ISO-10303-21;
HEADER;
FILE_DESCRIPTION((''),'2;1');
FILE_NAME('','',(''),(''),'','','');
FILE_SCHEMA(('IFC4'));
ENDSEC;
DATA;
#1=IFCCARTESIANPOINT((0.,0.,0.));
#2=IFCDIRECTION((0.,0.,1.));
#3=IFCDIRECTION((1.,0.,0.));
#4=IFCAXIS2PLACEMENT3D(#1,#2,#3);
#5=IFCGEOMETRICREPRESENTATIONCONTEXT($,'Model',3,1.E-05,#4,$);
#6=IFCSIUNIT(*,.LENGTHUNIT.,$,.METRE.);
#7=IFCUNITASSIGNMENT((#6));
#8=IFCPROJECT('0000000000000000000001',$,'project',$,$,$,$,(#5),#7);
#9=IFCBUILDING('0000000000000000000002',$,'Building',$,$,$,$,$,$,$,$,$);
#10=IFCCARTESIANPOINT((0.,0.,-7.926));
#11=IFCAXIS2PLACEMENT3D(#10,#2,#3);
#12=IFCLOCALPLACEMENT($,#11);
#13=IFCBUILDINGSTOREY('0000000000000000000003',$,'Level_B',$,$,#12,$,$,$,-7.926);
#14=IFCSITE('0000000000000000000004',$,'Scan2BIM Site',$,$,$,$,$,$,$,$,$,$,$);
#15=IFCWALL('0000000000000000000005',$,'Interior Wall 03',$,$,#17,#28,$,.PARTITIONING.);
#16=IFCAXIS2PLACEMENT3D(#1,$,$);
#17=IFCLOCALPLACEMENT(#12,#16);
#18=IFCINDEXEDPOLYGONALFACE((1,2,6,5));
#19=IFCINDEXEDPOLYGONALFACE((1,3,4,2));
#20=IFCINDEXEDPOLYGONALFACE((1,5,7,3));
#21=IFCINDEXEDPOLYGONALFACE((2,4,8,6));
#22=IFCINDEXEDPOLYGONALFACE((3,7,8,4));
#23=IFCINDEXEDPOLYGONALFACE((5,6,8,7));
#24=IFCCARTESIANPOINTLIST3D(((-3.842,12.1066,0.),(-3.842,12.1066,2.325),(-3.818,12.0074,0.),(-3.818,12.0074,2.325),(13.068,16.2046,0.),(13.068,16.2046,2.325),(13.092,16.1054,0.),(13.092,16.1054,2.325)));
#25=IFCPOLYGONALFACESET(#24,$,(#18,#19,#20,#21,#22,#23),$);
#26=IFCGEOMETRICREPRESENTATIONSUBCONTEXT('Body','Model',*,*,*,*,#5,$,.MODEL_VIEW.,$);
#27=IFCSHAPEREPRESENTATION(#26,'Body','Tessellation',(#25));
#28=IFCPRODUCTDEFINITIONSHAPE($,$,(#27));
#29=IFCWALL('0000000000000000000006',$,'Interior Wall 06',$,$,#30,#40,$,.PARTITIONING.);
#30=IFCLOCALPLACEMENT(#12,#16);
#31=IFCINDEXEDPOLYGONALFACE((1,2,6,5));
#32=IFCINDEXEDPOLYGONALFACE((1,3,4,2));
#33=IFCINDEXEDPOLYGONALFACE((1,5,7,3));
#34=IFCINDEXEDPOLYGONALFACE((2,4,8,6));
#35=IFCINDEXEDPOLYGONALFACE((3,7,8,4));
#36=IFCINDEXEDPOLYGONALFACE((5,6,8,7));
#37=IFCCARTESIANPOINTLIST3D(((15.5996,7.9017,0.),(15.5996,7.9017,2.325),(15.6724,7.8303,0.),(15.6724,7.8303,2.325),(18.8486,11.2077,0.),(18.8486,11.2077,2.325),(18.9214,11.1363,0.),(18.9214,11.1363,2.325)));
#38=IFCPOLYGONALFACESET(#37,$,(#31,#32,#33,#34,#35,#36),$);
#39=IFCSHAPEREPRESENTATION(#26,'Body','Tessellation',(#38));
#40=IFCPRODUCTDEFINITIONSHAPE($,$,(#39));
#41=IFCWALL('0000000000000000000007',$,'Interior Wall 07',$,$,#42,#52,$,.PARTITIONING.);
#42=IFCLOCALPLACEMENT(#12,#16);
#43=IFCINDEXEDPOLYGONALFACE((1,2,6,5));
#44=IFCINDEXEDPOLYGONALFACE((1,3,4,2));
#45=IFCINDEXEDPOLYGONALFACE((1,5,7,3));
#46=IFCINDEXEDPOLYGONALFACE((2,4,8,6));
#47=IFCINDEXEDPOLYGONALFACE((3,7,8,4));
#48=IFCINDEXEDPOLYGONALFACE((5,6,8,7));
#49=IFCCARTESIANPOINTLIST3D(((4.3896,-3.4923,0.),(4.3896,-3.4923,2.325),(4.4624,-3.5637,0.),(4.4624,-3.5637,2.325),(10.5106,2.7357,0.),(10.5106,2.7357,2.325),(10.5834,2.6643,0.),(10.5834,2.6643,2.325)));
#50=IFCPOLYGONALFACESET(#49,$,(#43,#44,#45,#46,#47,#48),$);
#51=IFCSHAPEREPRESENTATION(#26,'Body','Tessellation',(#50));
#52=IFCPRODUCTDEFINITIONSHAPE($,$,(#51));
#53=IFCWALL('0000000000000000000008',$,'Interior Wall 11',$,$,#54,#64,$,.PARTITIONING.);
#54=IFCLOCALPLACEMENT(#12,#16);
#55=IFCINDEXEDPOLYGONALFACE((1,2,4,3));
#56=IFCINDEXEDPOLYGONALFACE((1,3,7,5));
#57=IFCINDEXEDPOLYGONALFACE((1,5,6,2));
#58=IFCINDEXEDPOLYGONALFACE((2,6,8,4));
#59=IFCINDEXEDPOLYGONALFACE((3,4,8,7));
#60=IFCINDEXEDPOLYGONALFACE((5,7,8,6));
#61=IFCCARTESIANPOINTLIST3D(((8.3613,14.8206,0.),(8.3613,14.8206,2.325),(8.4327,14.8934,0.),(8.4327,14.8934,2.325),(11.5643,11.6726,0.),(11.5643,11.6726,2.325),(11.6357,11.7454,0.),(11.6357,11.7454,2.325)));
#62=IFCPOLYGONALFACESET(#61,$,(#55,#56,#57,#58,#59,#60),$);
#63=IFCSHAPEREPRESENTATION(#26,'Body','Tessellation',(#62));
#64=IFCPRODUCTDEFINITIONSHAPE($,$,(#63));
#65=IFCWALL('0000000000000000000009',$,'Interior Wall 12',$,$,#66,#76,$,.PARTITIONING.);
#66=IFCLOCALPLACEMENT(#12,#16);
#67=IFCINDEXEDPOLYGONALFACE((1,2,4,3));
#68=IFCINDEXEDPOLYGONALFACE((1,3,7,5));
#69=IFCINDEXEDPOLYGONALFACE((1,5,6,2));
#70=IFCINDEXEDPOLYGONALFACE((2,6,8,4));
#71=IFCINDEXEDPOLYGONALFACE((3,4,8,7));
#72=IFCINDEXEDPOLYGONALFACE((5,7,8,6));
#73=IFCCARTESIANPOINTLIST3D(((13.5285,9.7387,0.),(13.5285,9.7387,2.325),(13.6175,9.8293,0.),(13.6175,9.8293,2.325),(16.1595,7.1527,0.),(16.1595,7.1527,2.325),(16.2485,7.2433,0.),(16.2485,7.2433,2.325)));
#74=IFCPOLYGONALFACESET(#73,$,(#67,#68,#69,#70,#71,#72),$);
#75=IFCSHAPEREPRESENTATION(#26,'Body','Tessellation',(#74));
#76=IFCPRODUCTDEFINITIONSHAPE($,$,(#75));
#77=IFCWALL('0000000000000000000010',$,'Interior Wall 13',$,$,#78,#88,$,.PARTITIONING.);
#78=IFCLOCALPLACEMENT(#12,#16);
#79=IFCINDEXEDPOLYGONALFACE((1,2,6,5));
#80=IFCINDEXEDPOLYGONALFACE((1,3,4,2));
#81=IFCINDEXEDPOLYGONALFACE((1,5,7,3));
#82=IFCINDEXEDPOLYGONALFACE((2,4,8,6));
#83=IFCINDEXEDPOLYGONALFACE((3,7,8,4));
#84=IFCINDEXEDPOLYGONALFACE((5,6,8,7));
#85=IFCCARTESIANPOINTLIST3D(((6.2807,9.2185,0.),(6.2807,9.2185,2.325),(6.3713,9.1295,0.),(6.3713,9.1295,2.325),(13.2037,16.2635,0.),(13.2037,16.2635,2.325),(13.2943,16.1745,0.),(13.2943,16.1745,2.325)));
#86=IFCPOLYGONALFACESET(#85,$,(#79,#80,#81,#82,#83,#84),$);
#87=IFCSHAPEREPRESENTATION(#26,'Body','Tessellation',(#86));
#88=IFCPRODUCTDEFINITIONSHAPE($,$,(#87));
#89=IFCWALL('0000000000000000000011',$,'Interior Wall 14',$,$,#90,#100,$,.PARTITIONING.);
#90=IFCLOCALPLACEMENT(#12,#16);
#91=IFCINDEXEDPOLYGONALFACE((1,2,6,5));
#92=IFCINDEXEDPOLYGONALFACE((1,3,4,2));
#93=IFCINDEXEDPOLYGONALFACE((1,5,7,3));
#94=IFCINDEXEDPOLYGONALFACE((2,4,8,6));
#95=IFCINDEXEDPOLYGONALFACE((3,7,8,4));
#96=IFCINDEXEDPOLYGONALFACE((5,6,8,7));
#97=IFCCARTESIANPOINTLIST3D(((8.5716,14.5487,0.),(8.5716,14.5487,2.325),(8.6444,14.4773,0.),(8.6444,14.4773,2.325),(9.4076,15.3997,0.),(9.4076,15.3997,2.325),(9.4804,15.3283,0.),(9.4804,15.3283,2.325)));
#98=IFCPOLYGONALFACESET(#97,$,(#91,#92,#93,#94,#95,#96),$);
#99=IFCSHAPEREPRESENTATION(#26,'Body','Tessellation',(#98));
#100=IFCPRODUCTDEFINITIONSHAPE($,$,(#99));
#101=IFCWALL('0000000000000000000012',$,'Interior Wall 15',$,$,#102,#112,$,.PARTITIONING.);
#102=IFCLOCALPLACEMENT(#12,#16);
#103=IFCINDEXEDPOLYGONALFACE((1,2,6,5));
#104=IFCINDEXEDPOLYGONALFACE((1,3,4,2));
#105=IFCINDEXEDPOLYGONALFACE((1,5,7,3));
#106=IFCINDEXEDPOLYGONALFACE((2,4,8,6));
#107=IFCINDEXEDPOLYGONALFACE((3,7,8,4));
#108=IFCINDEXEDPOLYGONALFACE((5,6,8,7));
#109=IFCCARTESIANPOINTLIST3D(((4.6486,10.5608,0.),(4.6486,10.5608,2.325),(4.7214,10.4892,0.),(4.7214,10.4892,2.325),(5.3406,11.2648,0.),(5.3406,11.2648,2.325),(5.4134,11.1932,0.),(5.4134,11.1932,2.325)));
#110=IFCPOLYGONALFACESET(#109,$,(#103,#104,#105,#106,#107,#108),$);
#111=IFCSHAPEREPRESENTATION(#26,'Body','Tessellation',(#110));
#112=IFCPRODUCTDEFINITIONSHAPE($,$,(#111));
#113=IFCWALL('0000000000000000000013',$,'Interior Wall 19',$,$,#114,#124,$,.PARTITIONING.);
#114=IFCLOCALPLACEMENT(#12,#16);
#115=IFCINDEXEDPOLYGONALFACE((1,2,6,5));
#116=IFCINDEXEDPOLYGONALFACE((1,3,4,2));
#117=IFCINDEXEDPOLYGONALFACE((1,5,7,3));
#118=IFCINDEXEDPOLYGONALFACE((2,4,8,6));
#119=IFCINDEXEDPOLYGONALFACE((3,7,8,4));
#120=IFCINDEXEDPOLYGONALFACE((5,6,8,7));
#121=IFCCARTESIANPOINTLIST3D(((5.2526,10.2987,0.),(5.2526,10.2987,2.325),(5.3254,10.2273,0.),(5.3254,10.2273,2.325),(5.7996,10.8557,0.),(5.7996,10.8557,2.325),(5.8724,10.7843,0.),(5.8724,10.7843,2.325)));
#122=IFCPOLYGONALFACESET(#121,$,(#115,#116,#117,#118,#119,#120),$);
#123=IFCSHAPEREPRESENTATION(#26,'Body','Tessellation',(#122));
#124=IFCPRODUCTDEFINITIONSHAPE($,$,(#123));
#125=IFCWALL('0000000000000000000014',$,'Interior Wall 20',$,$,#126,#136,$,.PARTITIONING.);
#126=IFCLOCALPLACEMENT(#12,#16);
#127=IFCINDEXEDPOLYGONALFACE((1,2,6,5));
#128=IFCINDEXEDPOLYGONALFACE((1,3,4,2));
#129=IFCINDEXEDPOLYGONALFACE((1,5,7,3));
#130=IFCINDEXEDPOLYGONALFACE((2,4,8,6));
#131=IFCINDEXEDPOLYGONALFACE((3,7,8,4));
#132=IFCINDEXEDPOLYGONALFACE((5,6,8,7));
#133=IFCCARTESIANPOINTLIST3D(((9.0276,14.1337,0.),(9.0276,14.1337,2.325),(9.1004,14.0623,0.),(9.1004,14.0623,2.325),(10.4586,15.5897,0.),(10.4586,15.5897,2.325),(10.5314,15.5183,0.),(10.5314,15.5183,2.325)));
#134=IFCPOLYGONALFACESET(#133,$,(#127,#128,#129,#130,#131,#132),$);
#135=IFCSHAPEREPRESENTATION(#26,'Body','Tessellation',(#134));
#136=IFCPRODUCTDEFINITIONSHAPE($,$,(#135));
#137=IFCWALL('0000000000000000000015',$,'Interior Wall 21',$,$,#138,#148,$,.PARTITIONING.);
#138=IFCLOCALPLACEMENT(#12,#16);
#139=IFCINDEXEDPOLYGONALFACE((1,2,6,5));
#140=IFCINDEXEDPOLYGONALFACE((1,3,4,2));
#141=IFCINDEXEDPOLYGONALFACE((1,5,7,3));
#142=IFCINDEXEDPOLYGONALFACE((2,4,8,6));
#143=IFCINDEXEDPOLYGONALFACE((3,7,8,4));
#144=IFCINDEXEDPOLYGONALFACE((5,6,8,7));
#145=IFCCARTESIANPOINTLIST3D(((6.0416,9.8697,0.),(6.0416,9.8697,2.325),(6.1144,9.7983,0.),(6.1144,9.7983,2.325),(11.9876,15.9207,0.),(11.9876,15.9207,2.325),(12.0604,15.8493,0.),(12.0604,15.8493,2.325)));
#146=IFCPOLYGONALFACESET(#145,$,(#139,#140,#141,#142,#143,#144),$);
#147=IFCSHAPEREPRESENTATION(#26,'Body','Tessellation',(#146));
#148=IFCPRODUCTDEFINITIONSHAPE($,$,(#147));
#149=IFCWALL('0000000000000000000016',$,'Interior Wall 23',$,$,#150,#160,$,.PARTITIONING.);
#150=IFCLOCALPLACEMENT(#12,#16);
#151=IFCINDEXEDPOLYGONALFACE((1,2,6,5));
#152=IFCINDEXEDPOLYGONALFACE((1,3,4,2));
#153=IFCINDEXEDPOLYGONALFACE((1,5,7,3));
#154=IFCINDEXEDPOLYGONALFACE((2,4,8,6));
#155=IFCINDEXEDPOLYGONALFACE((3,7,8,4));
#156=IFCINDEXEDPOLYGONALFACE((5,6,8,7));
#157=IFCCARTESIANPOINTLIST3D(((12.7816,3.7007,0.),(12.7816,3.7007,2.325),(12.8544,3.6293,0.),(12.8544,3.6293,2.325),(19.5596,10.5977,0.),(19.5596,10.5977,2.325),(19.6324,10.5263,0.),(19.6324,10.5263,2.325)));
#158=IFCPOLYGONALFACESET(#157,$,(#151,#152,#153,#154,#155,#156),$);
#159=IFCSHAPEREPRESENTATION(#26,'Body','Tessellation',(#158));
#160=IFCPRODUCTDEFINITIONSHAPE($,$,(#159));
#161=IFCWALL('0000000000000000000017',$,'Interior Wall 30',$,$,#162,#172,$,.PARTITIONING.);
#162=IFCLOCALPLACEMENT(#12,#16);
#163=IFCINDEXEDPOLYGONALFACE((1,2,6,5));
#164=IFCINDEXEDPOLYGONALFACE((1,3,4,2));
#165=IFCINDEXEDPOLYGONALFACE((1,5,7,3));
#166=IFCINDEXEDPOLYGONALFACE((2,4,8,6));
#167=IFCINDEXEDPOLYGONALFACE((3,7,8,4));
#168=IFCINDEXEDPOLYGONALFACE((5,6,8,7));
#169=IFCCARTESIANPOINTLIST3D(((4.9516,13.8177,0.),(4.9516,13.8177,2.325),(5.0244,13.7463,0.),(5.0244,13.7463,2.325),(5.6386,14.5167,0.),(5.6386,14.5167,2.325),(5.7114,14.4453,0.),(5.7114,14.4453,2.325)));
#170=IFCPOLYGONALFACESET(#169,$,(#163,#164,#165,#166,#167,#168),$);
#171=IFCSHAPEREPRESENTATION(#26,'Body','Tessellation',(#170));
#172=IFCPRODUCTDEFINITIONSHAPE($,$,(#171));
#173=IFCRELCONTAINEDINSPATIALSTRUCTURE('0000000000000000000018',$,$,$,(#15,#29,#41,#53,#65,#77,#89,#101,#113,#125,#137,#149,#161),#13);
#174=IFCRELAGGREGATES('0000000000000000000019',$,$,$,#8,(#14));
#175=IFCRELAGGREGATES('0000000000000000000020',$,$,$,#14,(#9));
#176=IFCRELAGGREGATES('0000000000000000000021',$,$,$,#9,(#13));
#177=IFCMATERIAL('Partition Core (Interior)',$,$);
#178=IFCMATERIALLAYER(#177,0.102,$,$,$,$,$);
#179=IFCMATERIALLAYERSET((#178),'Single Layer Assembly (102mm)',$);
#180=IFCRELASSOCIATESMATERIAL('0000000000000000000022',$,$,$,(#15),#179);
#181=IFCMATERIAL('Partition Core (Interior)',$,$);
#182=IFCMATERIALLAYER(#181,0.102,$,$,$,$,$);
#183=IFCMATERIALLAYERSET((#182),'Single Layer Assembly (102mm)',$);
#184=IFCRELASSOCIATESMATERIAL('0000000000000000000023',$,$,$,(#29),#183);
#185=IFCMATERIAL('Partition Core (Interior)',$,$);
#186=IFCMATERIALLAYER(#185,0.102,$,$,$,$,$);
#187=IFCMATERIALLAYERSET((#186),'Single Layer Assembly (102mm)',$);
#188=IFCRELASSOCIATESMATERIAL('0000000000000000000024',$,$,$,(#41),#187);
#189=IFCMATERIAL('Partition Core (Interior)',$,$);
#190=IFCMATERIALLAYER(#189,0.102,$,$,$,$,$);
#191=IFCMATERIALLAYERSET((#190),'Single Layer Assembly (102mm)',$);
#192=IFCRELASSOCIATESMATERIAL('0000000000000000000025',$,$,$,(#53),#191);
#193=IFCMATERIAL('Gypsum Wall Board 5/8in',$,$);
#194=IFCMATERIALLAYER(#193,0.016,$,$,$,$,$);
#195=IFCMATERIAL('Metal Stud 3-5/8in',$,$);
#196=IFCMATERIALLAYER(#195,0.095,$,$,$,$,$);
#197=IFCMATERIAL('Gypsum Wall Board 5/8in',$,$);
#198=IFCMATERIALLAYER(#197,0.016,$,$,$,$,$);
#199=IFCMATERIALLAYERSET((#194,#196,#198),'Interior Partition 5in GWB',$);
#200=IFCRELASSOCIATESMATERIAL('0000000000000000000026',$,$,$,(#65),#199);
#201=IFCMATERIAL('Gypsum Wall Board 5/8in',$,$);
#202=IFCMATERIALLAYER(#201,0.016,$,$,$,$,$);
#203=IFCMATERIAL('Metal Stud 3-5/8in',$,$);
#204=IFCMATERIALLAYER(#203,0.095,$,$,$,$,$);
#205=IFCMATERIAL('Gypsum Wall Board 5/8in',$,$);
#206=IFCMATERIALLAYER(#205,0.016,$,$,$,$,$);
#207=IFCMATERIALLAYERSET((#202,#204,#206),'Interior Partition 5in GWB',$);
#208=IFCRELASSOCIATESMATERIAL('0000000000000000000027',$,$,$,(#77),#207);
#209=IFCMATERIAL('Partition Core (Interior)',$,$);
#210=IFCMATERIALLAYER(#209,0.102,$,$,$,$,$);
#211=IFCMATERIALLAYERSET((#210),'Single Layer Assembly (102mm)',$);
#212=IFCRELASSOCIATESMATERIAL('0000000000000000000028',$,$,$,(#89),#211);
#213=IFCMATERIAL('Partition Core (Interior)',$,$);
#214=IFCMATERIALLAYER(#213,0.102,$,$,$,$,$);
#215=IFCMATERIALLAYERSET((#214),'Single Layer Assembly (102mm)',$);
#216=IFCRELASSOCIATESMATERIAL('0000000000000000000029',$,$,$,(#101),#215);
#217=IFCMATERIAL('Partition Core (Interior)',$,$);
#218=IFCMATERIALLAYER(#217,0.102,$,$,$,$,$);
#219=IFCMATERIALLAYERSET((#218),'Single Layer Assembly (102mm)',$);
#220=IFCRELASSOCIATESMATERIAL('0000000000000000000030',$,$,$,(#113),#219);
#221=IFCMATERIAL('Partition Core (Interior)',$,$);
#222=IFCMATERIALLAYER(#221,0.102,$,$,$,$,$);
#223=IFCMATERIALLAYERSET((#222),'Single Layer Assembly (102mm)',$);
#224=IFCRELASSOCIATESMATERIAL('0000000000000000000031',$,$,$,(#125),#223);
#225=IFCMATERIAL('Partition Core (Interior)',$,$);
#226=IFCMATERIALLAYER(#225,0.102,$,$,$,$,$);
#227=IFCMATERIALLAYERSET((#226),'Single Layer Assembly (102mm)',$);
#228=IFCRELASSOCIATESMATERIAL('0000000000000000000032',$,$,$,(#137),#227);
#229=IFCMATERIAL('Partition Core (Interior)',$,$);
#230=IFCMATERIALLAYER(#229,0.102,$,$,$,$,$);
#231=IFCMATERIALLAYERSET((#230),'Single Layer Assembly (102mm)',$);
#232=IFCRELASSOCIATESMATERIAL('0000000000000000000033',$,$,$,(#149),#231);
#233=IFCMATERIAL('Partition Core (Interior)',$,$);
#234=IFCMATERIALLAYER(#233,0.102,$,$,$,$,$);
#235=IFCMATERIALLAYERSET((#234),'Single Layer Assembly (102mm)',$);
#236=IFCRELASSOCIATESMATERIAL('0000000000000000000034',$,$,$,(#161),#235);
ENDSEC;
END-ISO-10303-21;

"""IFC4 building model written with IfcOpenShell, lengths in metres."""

from ifc_helpers import new_model, si_unit, frame, origin, origin_with_axes, place, context, subcontext, project, spatial, rectangle, extrude, material, layer, layer_set, element, save


model = new_model("IFC4")

# Units and contexts
model_context = context("Model", 3, precision=1e-05, world=origin_with_axes())
body_context = subcontext(model_context, "Body", "Model", "MODEL_VIEW")
ifc_project = project(units=[si_unit("LENGTHUNIT", "METRE")], contexts=[model_context])

# Site, building, storey
site = spatial("IfcSite", under=ifc_project, Name="Scan2BIM Site")
building = spatial("IfcBuilding", under=site, Name="Building")
storey_placement = place(None, frame((0.0, 0.0, -7.926), z_axis=(0.0, 0.0, 1.0), x_axis=(1.0, 0.0, 0.0)))
storey = spatial("IfcBuildingStorey", under=building, at=storey_placement, Name="Level_B", Elevation=-7.926)

# Walls
ifc_material_1 = material(Name="Partition Core (Interior)")
ifc_layer_1 = layer(ifc_material_1, 0.102)
ifc_layer_set_1 = layer_set([ifc_layer_1], Name="Single Layer Assembly (102mm)")
wall_1_placement = place(storey_placement, frame((4.625, 14.106, 0.0), z_axis=(0.0, 0.0, 1.0), x_axis=(0.971868, 0.235524, 0.0)))
element("IfcWall", 1, at=wall_1_placement, inside=storey, material=ifc_layer_set_1, Name="Interior Wall 03", PredefinedType="PARTITIONING", context=body_context, shape_type="SweptSolid", body=[
    extrude(rectangle(XDim=17.3995, YDim=0.102), origin(), (0.0, 0.0, 1.0), 2.325),
])
ifc_material_2 = material(Name="Partition Core (Interior)")
ifc_layer_2 = layer(ifc_material_2, 0.102)
ifc_layer_set_2 = layer_set([ifc_layer_2], Name="Single Layer Assembly (102mm)")
wall_2_placement = place(storey_placement, frame((17.2605, 9.519, 0.0), z_axis=(0.0, 0.0, 1.0), x_axis=(-0.700932, -0.713229, 0.0)))
element("IfcWall", 2, at=wall_2_placement, inside=storey, material=ifc_layer_set_2, Name="Interior Wall 06", PredefinedType="PARTITIONING", context=body_context, shape_type="SweptSolid", body=[
    extrude(rectangle(XDim=4.6353, YDim=0.102), origin(), (0.0, 0.0, 1.0), 2.325),
])
ifc_material_3 = material(Name="Partition Core (Interior)")
ifc_layer_3 = layer(ifc_material_3, 0.102)
ifc_layer_set_3 = layer_set([ifc_layer_3], Name="Single Layer Assembly (102mm)")
wall_3_placement = place(storey_placement, frame((7.4865, -0.414, 0.0), z_axis=(0.0, 0.0, 1.0), x_axis=(-0.700954, -0.713207, 0.0)))
element("IfcWall", 3, at=wall_3_placement, inside=storey, material=ifc_layer_set_3, Name="Interior Wall 07", PredefinedType="PARTITIONING", context=body_context, shape_type="SweptSolid", body=[
    extrude(rectangle(XDim=8.7324, YDim=0.102), origin(), (0.0, 0.0, 1.0), 2.325),
])
ifc_material_4 = material(Name="Partition Core (Interior)")
ifc_layer_4 = layer(ifc_material_4, 0.102)
ifc_layer_set_4 = layer_set([ifc_layer_4], Name="Single Layer Assembly (102mm)")
wall_4_placement = place(storey_placement, frame((9.9985, 13.283, 0.0), z_axis=(0.0, 0.0, 1.0), x_axis=(0.713204, -0.700957, 0.0)))
element("IfcWall", 4, at=wall_4_placement, inside=storey, material=ifc_layer_set_4, Name="Interior Wall 11", PredefinedType="PARTITIONING", context=body_context, shape_type="SweptSolid", body=[
    extrude(rectangle(XDim=4.491, YDim=0.102), origin(), (0.0, 0.0, 1.0), 2.325),
])
ifc_material_5 = material(Name="Gypsum Wall Board 5/8in")
ifc_layer_5 = layer(ifc_material_5, 0.016)
ifc_material_6 = material(Name="Metal Stud 3-5/8in")
ifc_layer_6 = layer(ifc_material_6, 0.095)
ifc_material_7 = material(Name="Gypsum Wall Board 5/8in")
ifc_layer_7 = layer(ifc_material_7, 0.016)
ifc_layer_set_5 = layer_set([ifc_layer_5, ifc_layer_6, ifc_layer_7], Name="Interior Partition 5in GWB")
wall_5_placement = place(storey_placement, frame((14.8885, 8.491, 0.0), z_axis=(0.0, 0.0, 1.0), x_axis=(0.71318, -0.700981, 0.0)))
element("IfcWall", 5, at=wall_5_placement, inside=storey, material=ifc_layer_set_5, Name="Interior Wall 12", PredefinedType="PARTITIONING", context=body_context, shape_type="SweptSolid", body=[
    extrude(rectangle(XDim=3.6891, YDim=0.127), origin(), (0.0, 0.0, 1.0), 2.325),
])
ifc_material_8 = material(Name="Gypsum Wall Board 5/8in")
ifc_layer_8 = layer(ifc_material_8, 0.016)
ifc_material_9 = material(Name="Metal Stud 3-5/8in")
ifc_layer_9 = layer(ifc_material_9, 0.095)
ifc_material_10 = material(Name="Gypsum Wall Board 5/8in")
ifc_layer_10 = layer(ifc_material_10, 0.016)
ifc_layer_set_6 = layer_set([ifc_layer_8, ifc_layer_9, ifc_layer_10], Name="Interior Partition 5in GWB")
wall_6_placement = place(storey_placement, frame((9.7875, 12.6965, 0.0), z_axis=(0.0, 0.0, 1.0), x_axis=(0.700904, 0.713256, 0.0)))
element("IfcWall", 6, at=wall_6_placement, inside=storey, material=ifc_layer_set_6, Name="Interior Wall 13", PredefinedType="PARTITIONING", context=body_context, shape_type="SweptSolid", body=[
    extrude(rectangle(XDim=9.8772, YDim=0.127), origin(), (0.0, 0.0, 1.0), 2.325),
])
ifc_material_11 = material(Name="Partition Core (Interior)")
ifc_layer_11 = layer(ifc_material_11, 0.102)
ifc_layer_set_7 = layer_set([ifc_layer_11], Name="Single Layer Assembly (102mm)")
wall_7_placement = place(storey_placement, frame((9.026, 14.9385, 0.0), z_axis=(0.0, 0.0, 1.0), x_axis=(-0.700792, -0.713366, 0.0)))
element("IfcWall", 7, at=wall_7_placement, inside=storey, material=ifc_layer_set_7, Name="Interior Wall 14", PredefinedType="PARTITIONING", context=body_context, shape_type="SweptSolid", body=[
    extrude(rectangle(XDim=1.1929, YDim=0.102), origin(), (0.0, 0.0, 1.0), 2.325),
])
ifc_material_12 = material(Name="Partition Core (Interior)")
ifc_layer_12 = layer(ifc_material_12, 0.102)
ifc_layer_set_8 = layer_set([ifc_layer_12], Name="Single Layer Assembly (102mm)")
wall_8_placement = place(storey_placement, frame((5.031, 10.877, 0.0), z_axis=(0.0, 0.0, 1.0), x_axis=(-0.701003, -0.713159, 0.0)))
element("IfcWall", 8, at=wall_8_placement, inside=storey, material=ifc_layer_set_8, Name="Interior Wall 15", PredefinedType="PARTITIONING", context=body_context, shape_type="SweptSolid", body=[
    extrude(rectangle(XDim=0.9872, YDim=0.102), origin(), (0.0, 0.0, 1.0), 2.325),
])
ifc_material_13 = material(Name="Partition Core (Interior)")
ifc_layer_13 = layer(ifc_material_13, 0.102)
ifc_layer_set_9 = layer_set([ifc_layer_13], Name="Single Layer Assembly (102mm)")
wall_9_placement = place(storey_placement, frame((5.5625, 10.5415, 0.0), z_axis=(0.0, 0.0, 1.0), x_axis=(0.700673, 0.713482, 0.0)))
element("IfcWall", 9, at=wall_9_placement, inside=storey, material=ifc_layer_set_9, Name="Interior Wall 19", PredefinedType="PARTITIONING", context=body_context, shape_type="SweptSolid", body=[
    extrude(rectangle(XDim=0.7807, YDim=0.102), origin(), (0.0, 0.0, 1.0), 2.325),
])
ifc_material_14 = material(Name="Partition Core (Interior)")
ifc_layer_14 = layer(ifc_material_14, 0.102)
ifc_layer_set_10 = layer_set([ifc_layer_14], Name="Single Layer Assembly (102mm)")
wall_10_placement = place(storey_placement, frame((9.7795, 14.826, 0.0), z_axis=(0.0, 0.0, 1.0), x_axis=(0.700957, 0.713203, 0.0)))
element("IfcWall", 10, at=wall_10_placement, inside=storey, material=ifc_layer_set_10, Name="Interior Wall 20", PredefinedType="PARTITIONING", context=body_context, shape_type="SweptSolid", body=[
    extrude(rectangle(XDim=2.0415, YDim=0.102), origin(), (0.0, 0.0, 1.0), 2.325),
])
ifc_material_15 = material(Name="Partition Core (Interior)")
ifc_layer_15 = layer(ifc_material_15, 0.102)
ifc_layer_set_11 = layer_set([ifc_layer_15], Name="Single Layer Assembly (102mm)")
wall_11_placement = place(storey_placement, frame((9.051, 12.8595, 0.0), z_axis=(0.0, 0.0, 1.0), x_axis=(-0.700891, -0.713268, 0.0)))
element("IfcWall", 11, at=wall_11_placement, inside=storey, material=ifc_layer_set_11, Name="Interior Wall 21", PredefinedType="PARTITIONING", context=body_context, shape_type="SweptSolid", body=[
    extrude(rectangle(XDim=8.4835, YDim=0.102), origin(), (0.0, 0.0, 1.0), 2.325),
])
ifc_material_16 = material(Name="Partition Core (Interior)")
ifc_layer_16 = layer(ifc_material_16, 0.102)
ifc_layer_set_12 = layer_set([ifc_layer_16], Name="Single Layer Assembly (102mm)")
wall_12_placement = place(storey_placement, frame((16.207, 7.1135, 0.0), z_axis=(0.0, 0.0, 1.0), x_axis=(0.700927, 0.713233, 0.0)))
element("IfcWall", 12, at=wall_12_placement, inside=storey, material=ifc_layer_set_12, Name="Interior Wall 23", PredefinedType="PARTITIONING", context=body_context, shape_type="SweptSolid", body=[
    extrude(rectangle(XDim=9.6701, YDim=0.102), origin(), (0.0, 0.0, 1.0), 2.325),
])
ifc_material_17 = material(Name="Partition Core (Interior)")
ifc_layer_17 = layer(ifc_material_17, 0.102)
ifc_layer_set_13 = layer_set([ifc_layer_17], Name="Single Layer Assembly (102mm)")
wall_13_placement = place(storey_placement, frame((5.3315, 14.1315, 0.0), z_axis=(0.0, 0.0, 1.0), x_axis=(0.700958, 0.713202, 0.0)))
element("IfcWall", 13, at=wall_13_placement, inside=storey, material=ifc_layer_set_13, Name="Interior Wall 30", PredefinedType="PARTITIONING", context=body_context, shape_type="SweptSolid", body=[
    extrude(rectangle(XDim=0.9801, YDim=0.102), origin(), (0.0, 0.0, 1.0), 2.325),
])

save(model, "model.ifc")
